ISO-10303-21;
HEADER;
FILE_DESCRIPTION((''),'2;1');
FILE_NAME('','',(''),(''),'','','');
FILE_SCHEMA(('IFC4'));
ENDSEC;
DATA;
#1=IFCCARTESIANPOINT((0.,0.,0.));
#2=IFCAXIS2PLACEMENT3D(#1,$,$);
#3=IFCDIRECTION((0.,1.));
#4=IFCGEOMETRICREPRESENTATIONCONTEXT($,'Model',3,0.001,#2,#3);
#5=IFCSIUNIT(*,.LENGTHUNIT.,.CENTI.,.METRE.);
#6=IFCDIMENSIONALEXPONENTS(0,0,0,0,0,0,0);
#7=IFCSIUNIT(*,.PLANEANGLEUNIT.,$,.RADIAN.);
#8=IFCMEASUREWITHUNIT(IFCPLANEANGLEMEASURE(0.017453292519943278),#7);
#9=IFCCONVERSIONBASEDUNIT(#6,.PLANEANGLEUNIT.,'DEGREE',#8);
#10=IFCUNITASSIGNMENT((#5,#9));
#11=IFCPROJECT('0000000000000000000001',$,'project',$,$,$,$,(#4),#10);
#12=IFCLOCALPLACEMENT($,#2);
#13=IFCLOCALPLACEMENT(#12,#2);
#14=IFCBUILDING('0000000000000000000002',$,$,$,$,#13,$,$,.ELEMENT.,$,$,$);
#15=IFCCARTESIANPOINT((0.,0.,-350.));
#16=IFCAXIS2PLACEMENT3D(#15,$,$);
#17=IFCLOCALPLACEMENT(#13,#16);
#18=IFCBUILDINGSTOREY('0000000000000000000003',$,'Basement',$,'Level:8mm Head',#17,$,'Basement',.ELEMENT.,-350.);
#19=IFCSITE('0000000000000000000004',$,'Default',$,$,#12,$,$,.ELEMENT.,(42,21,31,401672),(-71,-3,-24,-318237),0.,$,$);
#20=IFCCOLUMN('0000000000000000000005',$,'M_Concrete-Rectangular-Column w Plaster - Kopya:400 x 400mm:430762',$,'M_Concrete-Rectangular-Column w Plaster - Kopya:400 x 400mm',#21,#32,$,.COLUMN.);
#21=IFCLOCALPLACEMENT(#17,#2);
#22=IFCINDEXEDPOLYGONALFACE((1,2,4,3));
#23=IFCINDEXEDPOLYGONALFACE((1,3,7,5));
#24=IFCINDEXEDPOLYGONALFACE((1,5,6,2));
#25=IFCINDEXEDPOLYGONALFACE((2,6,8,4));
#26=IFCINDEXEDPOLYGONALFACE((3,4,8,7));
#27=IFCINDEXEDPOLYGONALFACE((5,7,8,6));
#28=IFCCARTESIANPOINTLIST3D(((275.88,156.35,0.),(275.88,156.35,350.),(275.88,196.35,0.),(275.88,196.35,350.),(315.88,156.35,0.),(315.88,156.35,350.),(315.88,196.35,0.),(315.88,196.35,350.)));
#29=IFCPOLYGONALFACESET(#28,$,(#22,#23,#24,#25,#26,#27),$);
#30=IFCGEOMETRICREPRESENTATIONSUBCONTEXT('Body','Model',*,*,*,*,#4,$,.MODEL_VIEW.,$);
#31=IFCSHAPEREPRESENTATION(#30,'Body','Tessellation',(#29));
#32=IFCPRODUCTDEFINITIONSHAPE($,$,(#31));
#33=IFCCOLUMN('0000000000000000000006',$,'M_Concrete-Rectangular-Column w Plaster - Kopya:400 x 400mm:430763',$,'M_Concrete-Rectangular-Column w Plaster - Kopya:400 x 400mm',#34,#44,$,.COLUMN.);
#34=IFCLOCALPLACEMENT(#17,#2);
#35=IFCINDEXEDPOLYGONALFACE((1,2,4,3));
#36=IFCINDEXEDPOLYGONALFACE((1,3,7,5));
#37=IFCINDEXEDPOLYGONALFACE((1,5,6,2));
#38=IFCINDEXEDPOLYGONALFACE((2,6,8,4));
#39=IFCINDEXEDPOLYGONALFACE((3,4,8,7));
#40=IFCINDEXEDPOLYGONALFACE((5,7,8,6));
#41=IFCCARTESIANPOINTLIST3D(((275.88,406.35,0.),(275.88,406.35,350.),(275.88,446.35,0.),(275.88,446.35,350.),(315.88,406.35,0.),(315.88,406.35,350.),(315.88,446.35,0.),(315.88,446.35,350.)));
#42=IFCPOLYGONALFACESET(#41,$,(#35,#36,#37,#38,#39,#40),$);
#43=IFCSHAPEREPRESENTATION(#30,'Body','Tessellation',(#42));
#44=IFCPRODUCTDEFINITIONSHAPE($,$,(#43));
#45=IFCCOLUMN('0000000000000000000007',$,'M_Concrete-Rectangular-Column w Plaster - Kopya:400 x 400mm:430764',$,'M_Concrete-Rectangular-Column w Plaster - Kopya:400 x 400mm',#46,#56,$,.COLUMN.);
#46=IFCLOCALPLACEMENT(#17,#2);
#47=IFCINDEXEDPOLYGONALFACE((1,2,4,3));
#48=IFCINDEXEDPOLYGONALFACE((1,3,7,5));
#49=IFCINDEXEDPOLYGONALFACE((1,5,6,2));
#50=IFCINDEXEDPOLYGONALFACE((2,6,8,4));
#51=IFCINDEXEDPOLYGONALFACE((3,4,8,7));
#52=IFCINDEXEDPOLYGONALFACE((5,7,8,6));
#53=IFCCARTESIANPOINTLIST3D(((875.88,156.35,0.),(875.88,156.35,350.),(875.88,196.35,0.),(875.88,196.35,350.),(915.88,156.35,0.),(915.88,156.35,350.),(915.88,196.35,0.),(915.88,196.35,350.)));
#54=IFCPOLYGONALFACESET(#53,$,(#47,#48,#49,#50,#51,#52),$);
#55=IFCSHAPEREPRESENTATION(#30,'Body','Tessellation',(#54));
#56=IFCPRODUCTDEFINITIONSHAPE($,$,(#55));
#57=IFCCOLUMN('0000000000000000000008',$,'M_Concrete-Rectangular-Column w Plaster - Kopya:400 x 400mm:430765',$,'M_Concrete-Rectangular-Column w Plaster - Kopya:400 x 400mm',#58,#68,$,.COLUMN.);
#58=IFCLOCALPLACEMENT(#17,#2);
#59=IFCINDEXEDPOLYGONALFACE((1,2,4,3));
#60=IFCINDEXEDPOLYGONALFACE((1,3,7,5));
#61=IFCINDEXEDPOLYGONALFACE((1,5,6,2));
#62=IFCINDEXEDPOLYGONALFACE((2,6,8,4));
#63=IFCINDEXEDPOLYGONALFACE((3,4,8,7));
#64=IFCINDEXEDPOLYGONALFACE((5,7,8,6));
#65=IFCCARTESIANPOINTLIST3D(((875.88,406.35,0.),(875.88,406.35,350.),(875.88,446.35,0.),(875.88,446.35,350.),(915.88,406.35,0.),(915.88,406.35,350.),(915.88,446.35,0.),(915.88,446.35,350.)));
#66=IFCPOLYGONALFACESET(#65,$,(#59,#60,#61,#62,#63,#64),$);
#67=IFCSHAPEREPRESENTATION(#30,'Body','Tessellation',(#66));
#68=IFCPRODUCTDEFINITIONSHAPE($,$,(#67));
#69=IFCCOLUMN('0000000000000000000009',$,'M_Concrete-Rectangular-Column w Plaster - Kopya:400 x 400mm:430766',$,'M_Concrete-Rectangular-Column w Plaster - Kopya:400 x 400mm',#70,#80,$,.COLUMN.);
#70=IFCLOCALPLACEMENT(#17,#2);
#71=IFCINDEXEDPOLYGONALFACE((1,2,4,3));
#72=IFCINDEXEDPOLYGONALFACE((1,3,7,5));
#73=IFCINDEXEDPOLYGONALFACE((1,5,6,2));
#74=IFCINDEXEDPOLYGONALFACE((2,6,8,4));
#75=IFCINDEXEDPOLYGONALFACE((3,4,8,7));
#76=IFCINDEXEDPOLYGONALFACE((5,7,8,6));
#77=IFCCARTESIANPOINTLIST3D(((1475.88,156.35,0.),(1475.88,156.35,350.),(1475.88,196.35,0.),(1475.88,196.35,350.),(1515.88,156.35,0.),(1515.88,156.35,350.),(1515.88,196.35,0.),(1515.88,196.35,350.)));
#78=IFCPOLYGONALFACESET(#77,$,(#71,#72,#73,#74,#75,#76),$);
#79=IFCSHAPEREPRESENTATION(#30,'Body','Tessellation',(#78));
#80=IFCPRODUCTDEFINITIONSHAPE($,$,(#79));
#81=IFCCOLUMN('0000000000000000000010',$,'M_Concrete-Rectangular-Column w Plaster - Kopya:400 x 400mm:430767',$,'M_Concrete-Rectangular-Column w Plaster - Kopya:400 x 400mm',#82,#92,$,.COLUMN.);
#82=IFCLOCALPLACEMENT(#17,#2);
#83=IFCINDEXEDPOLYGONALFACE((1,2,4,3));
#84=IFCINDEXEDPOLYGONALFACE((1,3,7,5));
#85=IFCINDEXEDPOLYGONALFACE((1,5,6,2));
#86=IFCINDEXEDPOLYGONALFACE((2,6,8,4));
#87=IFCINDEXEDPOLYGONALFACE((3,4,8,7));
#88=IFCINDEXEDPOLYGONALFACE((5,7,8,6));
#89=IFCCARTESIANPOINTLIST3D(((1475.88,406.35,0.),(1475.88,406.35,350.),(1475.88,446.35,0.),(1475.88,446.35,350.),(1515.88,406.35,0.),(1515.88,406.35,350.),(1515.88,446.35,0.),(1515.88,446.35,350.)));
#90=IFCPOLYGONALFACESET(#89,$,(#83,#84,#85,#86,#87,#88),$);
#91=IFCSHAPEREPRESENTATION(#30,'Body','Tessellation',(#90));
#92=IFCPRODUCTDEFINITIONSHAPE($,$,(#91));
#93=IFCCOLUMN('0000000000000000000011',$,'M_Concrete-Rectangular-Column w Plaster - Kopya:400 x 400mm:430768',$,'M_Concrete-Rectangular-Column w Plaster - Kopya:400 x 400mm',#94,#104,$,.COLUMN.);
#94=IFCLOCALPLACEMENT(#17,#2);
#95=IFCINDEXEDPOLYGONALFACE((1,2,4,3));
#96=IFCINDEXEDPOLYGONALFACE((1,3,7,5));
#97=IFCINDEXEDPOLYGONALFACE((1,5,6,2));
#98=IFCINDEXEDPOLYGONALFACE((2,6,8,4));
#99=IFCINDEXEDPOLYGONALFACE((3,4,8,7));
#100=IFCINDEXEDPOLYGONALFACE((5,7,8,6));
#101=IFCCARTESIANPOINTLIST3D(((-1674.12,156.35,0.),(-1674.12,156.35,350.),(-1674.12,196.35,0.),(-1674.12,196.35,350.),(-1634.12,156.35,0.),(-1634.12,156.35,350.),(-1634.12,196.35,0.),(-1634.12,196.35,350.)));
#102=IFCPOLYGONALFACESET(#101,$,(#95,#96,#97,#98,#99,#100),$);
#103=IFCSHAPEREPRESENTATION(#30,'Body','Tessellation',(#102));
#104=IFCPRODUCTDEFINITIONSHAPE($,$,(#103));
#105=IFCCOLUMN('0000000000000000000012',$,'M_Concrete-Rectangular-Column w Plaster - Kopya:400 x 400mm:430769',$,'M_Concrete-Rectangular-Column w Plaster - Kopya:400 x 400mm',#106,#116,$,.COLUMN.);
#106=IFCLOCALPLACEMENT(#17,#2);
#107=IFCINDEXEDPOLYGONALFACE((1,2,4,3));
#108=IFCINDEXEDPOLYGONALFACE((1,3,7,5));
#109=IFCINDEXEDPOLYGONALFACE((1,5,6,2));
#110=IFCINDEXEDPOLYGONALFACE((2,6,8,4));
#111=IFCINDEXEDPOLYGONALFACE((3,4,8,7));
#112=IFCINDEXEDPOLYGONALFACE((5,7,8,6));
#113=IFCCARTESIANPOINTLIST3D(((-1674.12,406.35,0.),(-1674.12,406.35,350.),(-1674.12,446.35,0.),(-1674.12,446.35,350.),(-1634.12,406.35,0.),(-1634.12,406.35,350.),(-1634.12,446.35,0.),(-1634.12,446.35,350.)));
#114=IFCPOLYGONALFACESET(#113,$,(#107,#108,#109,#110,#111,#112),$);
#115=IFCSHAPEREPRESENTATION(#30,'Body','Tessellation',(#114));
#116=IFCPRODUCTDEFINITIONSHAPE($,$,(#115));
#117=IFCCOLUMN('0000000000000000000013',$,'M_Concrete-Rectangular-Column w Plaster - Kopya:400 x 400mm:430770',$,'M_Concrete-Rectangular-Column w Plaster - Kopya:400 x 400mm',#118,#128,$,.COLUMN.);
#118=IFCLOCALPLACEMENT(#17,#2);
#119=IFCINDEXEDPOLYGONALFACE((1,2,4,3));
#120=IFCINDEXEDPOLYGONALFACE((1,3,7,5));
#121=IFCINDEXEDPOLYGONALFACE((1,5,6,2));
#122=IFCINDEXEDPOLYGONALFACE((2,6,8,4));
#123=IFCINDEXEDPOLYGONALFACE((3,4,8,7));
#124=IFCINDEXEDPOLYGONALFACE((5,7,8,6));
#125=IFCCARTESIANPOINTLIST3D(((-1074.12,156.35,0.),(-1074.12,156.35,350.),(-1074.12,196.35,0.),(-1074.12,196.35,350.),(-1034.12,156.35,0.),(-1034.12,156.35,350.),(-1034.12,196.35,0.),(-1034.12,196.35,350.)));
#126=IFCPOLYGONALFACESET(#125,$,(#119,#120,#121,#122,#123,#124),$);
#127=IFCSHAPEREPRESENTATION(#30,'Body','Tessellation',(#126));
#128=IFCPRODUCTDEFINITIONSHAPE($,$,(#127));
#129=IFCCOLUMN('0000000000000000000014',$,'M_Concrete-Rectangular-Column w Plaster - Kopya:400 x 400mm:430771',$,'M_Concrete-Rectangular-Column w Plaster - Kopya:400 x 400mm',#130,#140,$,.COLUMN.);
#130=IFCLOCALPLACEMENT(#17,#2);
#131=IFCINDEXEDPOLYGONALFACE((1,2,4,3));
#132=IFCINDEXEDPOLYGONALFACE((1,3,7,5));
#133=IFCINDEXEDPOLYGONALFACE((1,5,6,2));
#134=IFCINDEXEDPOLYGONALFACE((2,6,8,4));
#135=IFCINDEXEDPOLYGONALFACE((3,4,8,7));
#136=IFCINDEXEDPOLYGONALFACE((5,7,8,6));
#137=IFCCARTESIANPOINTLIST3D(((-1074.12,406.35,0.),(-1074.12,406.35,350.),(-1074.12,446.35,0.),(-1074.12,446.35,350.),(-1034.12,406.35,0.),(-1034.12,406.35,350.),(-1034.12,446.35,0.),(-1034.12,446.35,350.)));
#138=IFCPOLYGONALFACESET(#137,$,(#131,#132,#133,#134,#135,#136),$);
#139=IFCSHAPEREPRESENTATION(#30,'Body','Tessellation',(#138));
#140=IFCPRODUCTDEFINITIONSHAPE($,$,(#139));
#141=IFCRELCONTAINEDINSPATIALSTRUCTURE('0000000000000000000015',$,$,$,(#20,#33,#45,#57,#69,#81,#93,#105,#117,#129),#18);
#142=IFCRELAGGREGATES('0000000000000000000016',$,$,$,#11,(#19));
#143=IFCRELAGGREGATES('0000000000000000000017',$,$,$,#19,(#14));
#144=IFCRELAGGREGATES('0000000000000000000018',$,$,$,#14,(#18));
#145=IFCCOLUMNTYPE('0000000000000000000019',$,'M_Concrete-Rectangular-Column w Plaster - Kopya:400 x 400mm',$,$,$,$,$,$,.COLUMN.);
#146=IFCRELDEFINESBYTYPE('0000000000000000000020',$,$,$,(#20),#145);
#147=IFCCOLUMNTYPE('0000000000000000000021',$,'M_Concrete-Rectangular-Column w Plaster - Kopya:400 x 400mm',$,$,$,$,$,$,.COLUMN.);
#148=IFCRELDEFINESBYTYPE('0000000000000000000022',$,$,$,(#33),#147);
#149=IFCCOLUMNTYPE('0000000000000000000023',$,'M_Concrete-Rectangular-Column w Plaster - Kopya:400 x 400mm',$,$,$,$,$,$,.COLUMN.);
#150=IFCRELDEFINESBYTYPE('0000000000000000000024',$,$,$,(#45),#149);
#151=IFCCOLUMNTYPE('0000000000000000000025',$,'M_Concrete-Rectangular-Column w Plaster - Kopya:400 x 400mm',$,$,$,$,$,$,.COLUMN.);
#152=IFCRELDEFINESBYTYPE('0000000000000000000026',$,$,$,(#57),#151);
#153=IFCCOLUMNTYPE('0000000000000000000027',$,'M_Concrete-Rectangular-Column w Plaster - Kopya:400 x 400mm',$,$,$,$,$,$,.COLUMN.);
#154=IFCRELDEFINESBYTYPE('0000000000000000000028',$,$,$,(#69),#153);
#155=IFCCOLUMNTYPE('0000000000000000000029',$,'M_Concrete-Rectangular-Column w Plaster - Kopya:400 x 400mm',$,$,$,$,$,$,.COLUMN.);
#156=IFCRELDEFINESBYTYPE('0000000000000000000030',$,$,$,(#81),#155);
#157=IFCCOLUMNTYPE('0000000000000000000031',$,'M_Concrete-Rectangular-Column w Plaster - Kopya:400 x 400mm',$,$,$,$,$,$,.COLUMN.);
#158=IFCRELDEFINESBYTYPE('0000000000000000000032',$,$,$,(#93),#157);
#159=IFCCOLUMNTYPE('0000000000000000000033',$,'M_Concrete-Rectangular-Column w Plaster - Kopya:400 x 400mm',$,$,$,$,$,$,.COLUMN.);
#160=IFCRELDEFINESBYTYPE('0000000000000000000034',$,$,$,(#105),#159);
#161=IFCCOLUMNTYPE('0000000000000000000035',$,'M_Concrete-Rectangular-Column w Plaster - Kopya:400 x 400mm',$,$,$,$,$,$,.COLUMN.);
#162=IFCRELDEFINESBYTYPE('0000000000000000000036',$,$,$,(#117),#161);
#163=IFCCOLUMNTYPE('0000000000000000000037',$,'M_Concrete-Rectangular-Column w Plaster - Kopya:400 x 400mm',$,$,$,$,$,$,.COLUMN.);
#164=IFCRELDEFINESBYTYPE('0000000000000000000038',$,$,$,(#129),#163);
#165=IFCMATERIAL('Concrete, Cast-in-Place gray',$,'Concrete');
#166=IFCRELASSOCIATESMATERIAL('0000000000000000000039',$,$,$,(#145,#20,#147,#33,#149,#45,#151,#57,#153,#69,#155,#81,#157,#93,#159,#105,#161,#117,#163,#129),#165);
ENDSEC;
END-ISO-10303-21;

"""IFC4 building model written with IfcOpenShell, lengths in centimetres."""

from ifc_helpers import new_model, entity, si_unit, converted_unit, direction, frame, origin, place, context, subcontext, project, spatial, indexed_curve, outline, extrude, source, transform, mapped, material, type_object, type_shapes, element, save


model = new_model("IFC4")

# Units and contexts
model_context = context("Model", 3, precision=0.001, world=origin(), true_north=direction((0.0, 1.0)))
body_context = subcontext(model_context, "Body", "Model", "MODEL_VIEW")
ifc_project = project(units=[si_unit("LENGTHUNIT", "METRE", prefix="CENTI"), converted_unit("PLANEANGLEUNIT", "DEGREE", entity("IfcPlaneAngleMeasure", 0.017453292519943278), si_unit("PLANEANGLEUNIT", "RADIAN"), dimensions=[0, 0, 0, 0, 0, 0, 0])], contexts=[model_context])

# Site, building, storey
site_placement = place(None, origin())
site = spatial("IfcSite", under=ifc_project, at=site_placement, Name="Default", CompositionType="ELEMENT", RefLatitude=(42, 21, 31, 401672), RefLongitude=(-71, -3, -24, -318237), RefElevation=0.0)
building_placement = place(site_placement, origin())
building = spatial("IfcBuilding", under=site, at=building_placement, CompositionType="ELEMENT")
storey_placement = place(building_placement, frame((0.0, 0.0, -350.0)))
storey = spatial("IfcBuildingStorey", under=building, at=storey_placement, Name="Basement", ObjectType="Level:8mm Head", LongName="Basement", CompositionType="ELEMENT", Elevation=-350.0)

# Columns
ifc_material_1 = material(Name="Concrete, Cast-in-Place gray", Category="Concrete")
column_type_1 = type_object("IfcColumnType", Name="M_Concrete-Rectangular-Column w Plaster - Kopya:400 x 400mm", PredefinedType="COLUMN", material=ifc_material_1)
shared_shape_1 = source(origin(), body_context, "Body", "SweptSolid", [
    extrude(outline(indexed_curve([(-20.0, -20.0), (20.0, -20.0), (20.0, 20.0), (-20.0, 20.0), (-20.0, -20.0)], self_intersect=False)), frame((295.88, 176.35, -350.0), z_axis=(0.0, 0.0, 1.0), x_axis=(-1.0, 0.0, 0.0)), (0.0, 0.0, 1.0), 350.0),
])
type_shapes(column_type_1, [shared_shape_1])
column_1_placement = place(storey_placement, frame((0.0, 0.0, 350.0)))
element("IfcColumn", 1, at=column_1_placement, inside=storey, type_object=column_type_1, material=ifc_material_1, Name="M_Concrete-Rectangular-Column w Plaster - Kopya:400 x 400mm:430762", ObjectType="M_Concrete-Rectangular-Column w Plaster - Kopya:400 x 400mm", PredefinedType="COLUMN", context=body_context, shape_type="MappedRepresentation", body=[
    mapped(shared_shape_1, transform((0.0, 0.0, 0.0), scale=1.0)),
])
column_type_2 = type_object("IfcColumnType", Name="M_Concrete-Rectangular-Column w Plaster - Kopya:400 x 400mm", PredefinedType="COLUMN", material=ifc_material_1)
shared_shape_2 = source(origin(), body_context, "Body", "SweptSolid", [
    extrude(outline(indexed_curve([(-20.0, -20.0), (20.0, -20.0), (20.0, 20.0), (-20.0, 20.0), (-20.0, -20.0)], self_intersect=False)), frame((295.88, 426.35, -350.0), z_axis=(0.0, 0.0, 1.0), x_axis=(-1.0, 0.0, 0.0)), (0.0, 0.0, 1.0), 350.0),
])
type_shapes(column_type_2, [shared_shape_2])
column_2_placement = place(storey_placement, frame((0.0, 0.0, 350.0)))
element("IfcColumn", 2, at=column_2_placement, inside=storey, type_object=column_type_2, material=ifc_material_1, Name="M_Concrete-Rectangular-Column w Plaster - Kopya:400 x 400mm:430763", ObjectType="M_Concrete-Rectangular-Column w Plaster - Kopya:400 x 400mm", PredefinedType="COLUMN", context=body_context, shape_type="MappedRepresentation", body=[
    mapped(shared_shape_2, transform((0.0, 0.0, 0.0), scale=1.0)),
])
column_type_3 = type_object("IfcColumnType", Name="M_Concrete-Rectangular-Column w Plaster - Kopya:400 x 400mm", PredefinedType="COLUMN", material=ifc_material_1)
shared_shape_3 = source(origin(), body_context, "Body", "SweptSolid", [
    extrude(outline(indexed_curve([(-20.0, -20.0), (20.0, -20.0), (20.0, 20.0), (-20.0, 20.0), (-20.0, -20.0)], self_intersect=False)), frame((895.88, 176.35, -350.0), z_axis=(0.0, 0.0, 1.0), x_axis=(-1.0, 0.0, 0.0)), (0.0, 0.0, 1.0), 350.0),
])
type_shapes(column_type_3, [shared_shape_3])
column_3_placement = place(storey_placement, frame((0.0, 0.0, 350.0)))
element("IfcColumn", 3, at=column_3_placement, inside=storey, type_object=column_type_3, material=ifc_material_1, Name="M_Concrete-Rectangular-Column w Plaster - Kopya:400 x 400mm:430764", ObjectType="M_Concrete-Rectangular-Column w Plaster - Kopya:400 x 400mm", PredefinedType="COLUMN", context=body_context, shape_type="MappedRepresentation", body=[
    mapped(shared_shape_3, transform((0.0, 0.0, 0.0), scale=1.0)),
])
column_type_4 = type_object("IfcColumnType", Name="M_Concrete-Rectangular-Column w Plaster - Kopya:400 x 400mm", PredefinedType="COLUMN", material=ifc_material_1)
shared_shape_4 = source(origin(), body_context, "Body", "SweptSolid", [
    extrude(outline(indexed_curve([(-20.0, -20.0), (20.0, -20.0), (20.0, 20.0), (-20.0, 20.0), (-20.0, -20.0)], self_intersect=False)), frame((895.88, 426.35, -350.0), z_axis=(0.0, 0.0, 1.0), x_axis=(-1.0, 0.0, 0.0)), (0.0, 0.0, 1.0), 350.0),
])
type_shapes(column_type_4, [shared_shape_4])
column_4_placement = place(storey_placement, frame((0.0, 0.0, 350.0)))
element("IfcColumn", 4, at=column_4_placement, inside=storey, type_object=column_type_4, material=ifc_material_1, Name="M_Concrete-Rectangular-Column w Plaster - Kopya:400 x 400mm:430765", ObjectType="M_Concrete-Rectangular-Column w Plaster - Kopya:400 x 400mm", PredefinedType="COLUMN", context=body_context, shape_type="MappedRepresentation", body=[
    mapped(shared_shape_4, transform((0.0, 0.0, 0.0), scale=1.0)),
])
column_type_5 = type_object("IfcColumnType", Name="M_Concrete-Rectangular-Column w Plaster - Kopya:400 x 400mm", PredefinedType="COLUMN", material=ifc_material_1)
shared_shape_5 = source(origin(), body_context, "Body", "SweptSolid", [
    extrude(outline(indexed_curve([(-20.0, -20.0), (20.0, -20.0), (20.0, 20.0), (-20.0, 20.0), (-20.0, -20.0)], self_intersect=False)), frame((1495.88, 176.35, -350.0), z_axis=(0.0, 0.0, 1.0), x_axis=(-1.0, 0.0, 0.0)), (0.0, 0.0, 1.0), 350.0),
])
type_shapes(column_type_5, [shared_shape_5])
column_5_placement = place(storey_placement, frame((0.0, 0.0, 350.0)))
element("IfcColumn", 5, at=column_5_placement, inside=storey, type_object=column_type_5, material=ifc_material_1, Name="M_Concrete-Rectangular-Column w Plaster - Kopya:400 x 400mm:430766", ObjectType="M_Concrete-Rectangular-Column w Plaster - Kopya:400 x 400mm", PredefinedType="COLUMN", context=body_context, shape_type="MappedRepresentation", body=[
    mapped(shared_shape_5, transform((0.0, 0.0, 0.0), scale=1.0)),
])
column_type_6 = type_object("IfcColumnType", Name="M_Concrete-Rectangular-Column w Plaster - Kopya:400 x 400mm", PredefinedType="COLUMN", material=ifc_material_1)
shared_shape_6 = source(origin(), body_context, "Body", "SweptSolid", [
    extrude(outline(indexed_curve([(-20.0, -20.0), (20.0, -20.0), (20.0, 20.0), (-20.0, 20.0), (-20.0, -20.0)], self_intersect=False)), frame((1495.88, 426.35, -350.0), z_axis=(0.0, 0.0, 1.0), x_axis=(-1.0, 0.0, 0.0)), (0.0, 0.0, 1.0), 350.0),
])
type_shapes(column_type_6, [shared_shape_6])
column_6_placement = place(storey_placement, frame((0.0, 0.0, 350.0)))
element("IfcColumn", 6, at=column_6_placement, inside=storey, type_object=column_type_6, material=ifc_material_1, Name="M_Concrete-Rectangular-Column w Plaster - Kopya:400 x 400mm:430767", ObjectType="M_Concrete-Rectangular-Column w Plaster - Kopya:400 x 400mm", PredefinedType="COLUMN", context=body_context, shape_type="MappedRepresentation", body=[
    mapped(shared_shape_6, transform((0.0, 0.0, 0.0), scale=1.0)),
])
column_type_7 = type_object("IfcColumnType", Name="M_Concrete-Rectangular-Column w Plaster - Kopya:400 x 400mm", PredefinedType="COLUMN", material=ifc_material_1)
shared_shape_7 = source(origin(), body_context, "Body", "SweptSolid", [
    extrude(outline(indexed_curve([(-20.0, -20.0), (20.0, -20.0), (20.0, 20.0), (-20.0, 20.0), (-20.0, -20.0)], self_intersect=False)), frame((-1654.12, 176.35, -350.0), z_axis=(0.0, 0.0, 1.0), x_axis=(-1.0, 0.0, 0.0)), (0.0, 0.0, 1.0), 350.0),
])
type_shapes(column_type_7, [shared_shape_7])
column_7_placement = place(storey_placement, frame((0.0, 0.0, 350.0)))
element("IfcColumn", 7, at=column_7_placement, inside=storey, type_object=column_type_7, material=ifc_material_1, Name="M_Concrete-Rectangular-Column w Plaster - Kopya:400 x 400mm:430768", ObjectType="M_Concrete-Rectangular-Column w Plaster - Kopya:400 x 400mm", PredefinedType="COLUMN", context=body_context, shape_type="MappedRepresentation", body=[
    mapped(shared_shape_7, transform((0.0, 0.0, 0.0), scale=1.0)),
])
column_type_8 = type_object("IfcColumnType", Name="M_Concrete-Rectangular-Column w Plaster - Kopya:400 x 400mm", PredefinedType="COLUMN", material=ifc_material_1)
shared_shape_8 = source(origin(), body_context, "Body", "SweptSolid", [
    extrude(outline(indexed_curve([(-20.0, -20.0), (20.0, -20.0), (20.0, 20.0), (-20.0, 20.0), (-20.0, -20.0)], self_intersect=False)), frame((-1654.12, 426.35, -350.0), z_axis=(0.0, 0.0, 1.0), x_axis=(-1.0, 0.0, 0.0)), (0.0, 0.0, 1.0), 350.0),
])
type_shapes(column_type_8, [shared_shape_8])
column_8_placement = place(storey_placement, frame((0.0, 0.0, 350.0)))
element("IfcColumn", 8, at=column_8_placement, inside=storey, type_object=column_type_8, material=ifc_material_1, Name="M_Concrete-Rectangular-Column w Plaster - Kopya:400 x 400mm:430769", ObjectType="M_Concrete-Rectangular-Column w Plaster - Kopya:400 x 400mm", PredefinedType="COLUMN", context=body_context, shape_type="MappedRepresentation", body=[
    mapped(shared_shape_8, transform((0.0, 0.0, 0.0), scale=1.0)),
])
column_type_9 = type_object("IfcColumnType", Name="M_Concrete-Rectangular-Column w Plaster - Kopya:400 x 400mm", PredefinedType="COLUMN", material=ifc_material_1)
shared_shape_9 = source(origin(), body_context, "Body", "SweptSolid", [
    extrude(outline(indexed_curve([(-20.0, -20.0), (20.0, -20.0), (20.0, 20.0), (-20.0, 20.0), (-20.0, -20.0)], self_intersect=False)), frame((-1054.12, 176.35, -350.0), z_axis=(0.0, 0.0, 1.0), x_axis=(-1.0, 0.0, 0.0)), (0.0, 0.0, 1.0), 350.0),
])
type_shapes(column_type_9, [shared_shape_9])
column_9_placement = place(storey_placement, frame((0.0, 0.0, 350.0)))
element("IfcColumn", 9, at=column_9_placement, inside=storey, type_object=column_type_9, material=ifc_material_1, Name="M_Concrete-Rectangular-Column w Plaster - Kopya:400 x 400mm:430770", ObjectType="M_Concrete-Rectangular-Column w Plaster - Kopya:400 x 400mm", PredefinedType="COLUMN", context=body_context, shape_type="MappedRepresentation", body=[
    mapped(shared_shape_9, transform((0.0, 0.0, 0.0), scale=1.0)),
])
column_type_10 = type_object("IfcColumnType", Name="M_Concrete-Rectangular-Column w Plaster - Kopya:400 x 400mm", PredefinedType="COLUMN", material=ifc_material_1)
shared_shape_10 = source(origin(), body_context, "Body", "SweptSolid", [
    extrude(outline(indexed_curve([(-20.0, -20.0), (20.0, -20.0), (20.0, 20.0), (-20.0, 20.0), (-20.0, -20.0)], self_intersect=False)), frame((-1054.12, 426.35, -350.0), z_axis=(0.0, 0.0, 1.0), x_axis=(-1.0, 0.0, 0.0)), (0.0, 0.0, 1.0), 350.0),
])
type_shapes(column_type_10, [shared_shape_10])
column_10_placement = place(storey_placement, frame((0.0, 0.0, 350.0)))
element("IfcColumn", 10, at=column_10_placement, inside=storey, type_object=column_type_10, material=ifc_material_1, Name="M_Concrete-Rectangular-Column w Plaster - Kopya:400 x 400mm:430771", ObjectType="M_Concrete-Rectangular-Column w Plaster - Kopya:400 x 400mm", PredefinedType="COLUMN", context=body_context, shape_type="MappedRepresentation", body=[
    mapped(shared_shape_10, transform((0.0, 0.0, 0.0), scale=1.0)),
])

save(model, "model.ifc")
